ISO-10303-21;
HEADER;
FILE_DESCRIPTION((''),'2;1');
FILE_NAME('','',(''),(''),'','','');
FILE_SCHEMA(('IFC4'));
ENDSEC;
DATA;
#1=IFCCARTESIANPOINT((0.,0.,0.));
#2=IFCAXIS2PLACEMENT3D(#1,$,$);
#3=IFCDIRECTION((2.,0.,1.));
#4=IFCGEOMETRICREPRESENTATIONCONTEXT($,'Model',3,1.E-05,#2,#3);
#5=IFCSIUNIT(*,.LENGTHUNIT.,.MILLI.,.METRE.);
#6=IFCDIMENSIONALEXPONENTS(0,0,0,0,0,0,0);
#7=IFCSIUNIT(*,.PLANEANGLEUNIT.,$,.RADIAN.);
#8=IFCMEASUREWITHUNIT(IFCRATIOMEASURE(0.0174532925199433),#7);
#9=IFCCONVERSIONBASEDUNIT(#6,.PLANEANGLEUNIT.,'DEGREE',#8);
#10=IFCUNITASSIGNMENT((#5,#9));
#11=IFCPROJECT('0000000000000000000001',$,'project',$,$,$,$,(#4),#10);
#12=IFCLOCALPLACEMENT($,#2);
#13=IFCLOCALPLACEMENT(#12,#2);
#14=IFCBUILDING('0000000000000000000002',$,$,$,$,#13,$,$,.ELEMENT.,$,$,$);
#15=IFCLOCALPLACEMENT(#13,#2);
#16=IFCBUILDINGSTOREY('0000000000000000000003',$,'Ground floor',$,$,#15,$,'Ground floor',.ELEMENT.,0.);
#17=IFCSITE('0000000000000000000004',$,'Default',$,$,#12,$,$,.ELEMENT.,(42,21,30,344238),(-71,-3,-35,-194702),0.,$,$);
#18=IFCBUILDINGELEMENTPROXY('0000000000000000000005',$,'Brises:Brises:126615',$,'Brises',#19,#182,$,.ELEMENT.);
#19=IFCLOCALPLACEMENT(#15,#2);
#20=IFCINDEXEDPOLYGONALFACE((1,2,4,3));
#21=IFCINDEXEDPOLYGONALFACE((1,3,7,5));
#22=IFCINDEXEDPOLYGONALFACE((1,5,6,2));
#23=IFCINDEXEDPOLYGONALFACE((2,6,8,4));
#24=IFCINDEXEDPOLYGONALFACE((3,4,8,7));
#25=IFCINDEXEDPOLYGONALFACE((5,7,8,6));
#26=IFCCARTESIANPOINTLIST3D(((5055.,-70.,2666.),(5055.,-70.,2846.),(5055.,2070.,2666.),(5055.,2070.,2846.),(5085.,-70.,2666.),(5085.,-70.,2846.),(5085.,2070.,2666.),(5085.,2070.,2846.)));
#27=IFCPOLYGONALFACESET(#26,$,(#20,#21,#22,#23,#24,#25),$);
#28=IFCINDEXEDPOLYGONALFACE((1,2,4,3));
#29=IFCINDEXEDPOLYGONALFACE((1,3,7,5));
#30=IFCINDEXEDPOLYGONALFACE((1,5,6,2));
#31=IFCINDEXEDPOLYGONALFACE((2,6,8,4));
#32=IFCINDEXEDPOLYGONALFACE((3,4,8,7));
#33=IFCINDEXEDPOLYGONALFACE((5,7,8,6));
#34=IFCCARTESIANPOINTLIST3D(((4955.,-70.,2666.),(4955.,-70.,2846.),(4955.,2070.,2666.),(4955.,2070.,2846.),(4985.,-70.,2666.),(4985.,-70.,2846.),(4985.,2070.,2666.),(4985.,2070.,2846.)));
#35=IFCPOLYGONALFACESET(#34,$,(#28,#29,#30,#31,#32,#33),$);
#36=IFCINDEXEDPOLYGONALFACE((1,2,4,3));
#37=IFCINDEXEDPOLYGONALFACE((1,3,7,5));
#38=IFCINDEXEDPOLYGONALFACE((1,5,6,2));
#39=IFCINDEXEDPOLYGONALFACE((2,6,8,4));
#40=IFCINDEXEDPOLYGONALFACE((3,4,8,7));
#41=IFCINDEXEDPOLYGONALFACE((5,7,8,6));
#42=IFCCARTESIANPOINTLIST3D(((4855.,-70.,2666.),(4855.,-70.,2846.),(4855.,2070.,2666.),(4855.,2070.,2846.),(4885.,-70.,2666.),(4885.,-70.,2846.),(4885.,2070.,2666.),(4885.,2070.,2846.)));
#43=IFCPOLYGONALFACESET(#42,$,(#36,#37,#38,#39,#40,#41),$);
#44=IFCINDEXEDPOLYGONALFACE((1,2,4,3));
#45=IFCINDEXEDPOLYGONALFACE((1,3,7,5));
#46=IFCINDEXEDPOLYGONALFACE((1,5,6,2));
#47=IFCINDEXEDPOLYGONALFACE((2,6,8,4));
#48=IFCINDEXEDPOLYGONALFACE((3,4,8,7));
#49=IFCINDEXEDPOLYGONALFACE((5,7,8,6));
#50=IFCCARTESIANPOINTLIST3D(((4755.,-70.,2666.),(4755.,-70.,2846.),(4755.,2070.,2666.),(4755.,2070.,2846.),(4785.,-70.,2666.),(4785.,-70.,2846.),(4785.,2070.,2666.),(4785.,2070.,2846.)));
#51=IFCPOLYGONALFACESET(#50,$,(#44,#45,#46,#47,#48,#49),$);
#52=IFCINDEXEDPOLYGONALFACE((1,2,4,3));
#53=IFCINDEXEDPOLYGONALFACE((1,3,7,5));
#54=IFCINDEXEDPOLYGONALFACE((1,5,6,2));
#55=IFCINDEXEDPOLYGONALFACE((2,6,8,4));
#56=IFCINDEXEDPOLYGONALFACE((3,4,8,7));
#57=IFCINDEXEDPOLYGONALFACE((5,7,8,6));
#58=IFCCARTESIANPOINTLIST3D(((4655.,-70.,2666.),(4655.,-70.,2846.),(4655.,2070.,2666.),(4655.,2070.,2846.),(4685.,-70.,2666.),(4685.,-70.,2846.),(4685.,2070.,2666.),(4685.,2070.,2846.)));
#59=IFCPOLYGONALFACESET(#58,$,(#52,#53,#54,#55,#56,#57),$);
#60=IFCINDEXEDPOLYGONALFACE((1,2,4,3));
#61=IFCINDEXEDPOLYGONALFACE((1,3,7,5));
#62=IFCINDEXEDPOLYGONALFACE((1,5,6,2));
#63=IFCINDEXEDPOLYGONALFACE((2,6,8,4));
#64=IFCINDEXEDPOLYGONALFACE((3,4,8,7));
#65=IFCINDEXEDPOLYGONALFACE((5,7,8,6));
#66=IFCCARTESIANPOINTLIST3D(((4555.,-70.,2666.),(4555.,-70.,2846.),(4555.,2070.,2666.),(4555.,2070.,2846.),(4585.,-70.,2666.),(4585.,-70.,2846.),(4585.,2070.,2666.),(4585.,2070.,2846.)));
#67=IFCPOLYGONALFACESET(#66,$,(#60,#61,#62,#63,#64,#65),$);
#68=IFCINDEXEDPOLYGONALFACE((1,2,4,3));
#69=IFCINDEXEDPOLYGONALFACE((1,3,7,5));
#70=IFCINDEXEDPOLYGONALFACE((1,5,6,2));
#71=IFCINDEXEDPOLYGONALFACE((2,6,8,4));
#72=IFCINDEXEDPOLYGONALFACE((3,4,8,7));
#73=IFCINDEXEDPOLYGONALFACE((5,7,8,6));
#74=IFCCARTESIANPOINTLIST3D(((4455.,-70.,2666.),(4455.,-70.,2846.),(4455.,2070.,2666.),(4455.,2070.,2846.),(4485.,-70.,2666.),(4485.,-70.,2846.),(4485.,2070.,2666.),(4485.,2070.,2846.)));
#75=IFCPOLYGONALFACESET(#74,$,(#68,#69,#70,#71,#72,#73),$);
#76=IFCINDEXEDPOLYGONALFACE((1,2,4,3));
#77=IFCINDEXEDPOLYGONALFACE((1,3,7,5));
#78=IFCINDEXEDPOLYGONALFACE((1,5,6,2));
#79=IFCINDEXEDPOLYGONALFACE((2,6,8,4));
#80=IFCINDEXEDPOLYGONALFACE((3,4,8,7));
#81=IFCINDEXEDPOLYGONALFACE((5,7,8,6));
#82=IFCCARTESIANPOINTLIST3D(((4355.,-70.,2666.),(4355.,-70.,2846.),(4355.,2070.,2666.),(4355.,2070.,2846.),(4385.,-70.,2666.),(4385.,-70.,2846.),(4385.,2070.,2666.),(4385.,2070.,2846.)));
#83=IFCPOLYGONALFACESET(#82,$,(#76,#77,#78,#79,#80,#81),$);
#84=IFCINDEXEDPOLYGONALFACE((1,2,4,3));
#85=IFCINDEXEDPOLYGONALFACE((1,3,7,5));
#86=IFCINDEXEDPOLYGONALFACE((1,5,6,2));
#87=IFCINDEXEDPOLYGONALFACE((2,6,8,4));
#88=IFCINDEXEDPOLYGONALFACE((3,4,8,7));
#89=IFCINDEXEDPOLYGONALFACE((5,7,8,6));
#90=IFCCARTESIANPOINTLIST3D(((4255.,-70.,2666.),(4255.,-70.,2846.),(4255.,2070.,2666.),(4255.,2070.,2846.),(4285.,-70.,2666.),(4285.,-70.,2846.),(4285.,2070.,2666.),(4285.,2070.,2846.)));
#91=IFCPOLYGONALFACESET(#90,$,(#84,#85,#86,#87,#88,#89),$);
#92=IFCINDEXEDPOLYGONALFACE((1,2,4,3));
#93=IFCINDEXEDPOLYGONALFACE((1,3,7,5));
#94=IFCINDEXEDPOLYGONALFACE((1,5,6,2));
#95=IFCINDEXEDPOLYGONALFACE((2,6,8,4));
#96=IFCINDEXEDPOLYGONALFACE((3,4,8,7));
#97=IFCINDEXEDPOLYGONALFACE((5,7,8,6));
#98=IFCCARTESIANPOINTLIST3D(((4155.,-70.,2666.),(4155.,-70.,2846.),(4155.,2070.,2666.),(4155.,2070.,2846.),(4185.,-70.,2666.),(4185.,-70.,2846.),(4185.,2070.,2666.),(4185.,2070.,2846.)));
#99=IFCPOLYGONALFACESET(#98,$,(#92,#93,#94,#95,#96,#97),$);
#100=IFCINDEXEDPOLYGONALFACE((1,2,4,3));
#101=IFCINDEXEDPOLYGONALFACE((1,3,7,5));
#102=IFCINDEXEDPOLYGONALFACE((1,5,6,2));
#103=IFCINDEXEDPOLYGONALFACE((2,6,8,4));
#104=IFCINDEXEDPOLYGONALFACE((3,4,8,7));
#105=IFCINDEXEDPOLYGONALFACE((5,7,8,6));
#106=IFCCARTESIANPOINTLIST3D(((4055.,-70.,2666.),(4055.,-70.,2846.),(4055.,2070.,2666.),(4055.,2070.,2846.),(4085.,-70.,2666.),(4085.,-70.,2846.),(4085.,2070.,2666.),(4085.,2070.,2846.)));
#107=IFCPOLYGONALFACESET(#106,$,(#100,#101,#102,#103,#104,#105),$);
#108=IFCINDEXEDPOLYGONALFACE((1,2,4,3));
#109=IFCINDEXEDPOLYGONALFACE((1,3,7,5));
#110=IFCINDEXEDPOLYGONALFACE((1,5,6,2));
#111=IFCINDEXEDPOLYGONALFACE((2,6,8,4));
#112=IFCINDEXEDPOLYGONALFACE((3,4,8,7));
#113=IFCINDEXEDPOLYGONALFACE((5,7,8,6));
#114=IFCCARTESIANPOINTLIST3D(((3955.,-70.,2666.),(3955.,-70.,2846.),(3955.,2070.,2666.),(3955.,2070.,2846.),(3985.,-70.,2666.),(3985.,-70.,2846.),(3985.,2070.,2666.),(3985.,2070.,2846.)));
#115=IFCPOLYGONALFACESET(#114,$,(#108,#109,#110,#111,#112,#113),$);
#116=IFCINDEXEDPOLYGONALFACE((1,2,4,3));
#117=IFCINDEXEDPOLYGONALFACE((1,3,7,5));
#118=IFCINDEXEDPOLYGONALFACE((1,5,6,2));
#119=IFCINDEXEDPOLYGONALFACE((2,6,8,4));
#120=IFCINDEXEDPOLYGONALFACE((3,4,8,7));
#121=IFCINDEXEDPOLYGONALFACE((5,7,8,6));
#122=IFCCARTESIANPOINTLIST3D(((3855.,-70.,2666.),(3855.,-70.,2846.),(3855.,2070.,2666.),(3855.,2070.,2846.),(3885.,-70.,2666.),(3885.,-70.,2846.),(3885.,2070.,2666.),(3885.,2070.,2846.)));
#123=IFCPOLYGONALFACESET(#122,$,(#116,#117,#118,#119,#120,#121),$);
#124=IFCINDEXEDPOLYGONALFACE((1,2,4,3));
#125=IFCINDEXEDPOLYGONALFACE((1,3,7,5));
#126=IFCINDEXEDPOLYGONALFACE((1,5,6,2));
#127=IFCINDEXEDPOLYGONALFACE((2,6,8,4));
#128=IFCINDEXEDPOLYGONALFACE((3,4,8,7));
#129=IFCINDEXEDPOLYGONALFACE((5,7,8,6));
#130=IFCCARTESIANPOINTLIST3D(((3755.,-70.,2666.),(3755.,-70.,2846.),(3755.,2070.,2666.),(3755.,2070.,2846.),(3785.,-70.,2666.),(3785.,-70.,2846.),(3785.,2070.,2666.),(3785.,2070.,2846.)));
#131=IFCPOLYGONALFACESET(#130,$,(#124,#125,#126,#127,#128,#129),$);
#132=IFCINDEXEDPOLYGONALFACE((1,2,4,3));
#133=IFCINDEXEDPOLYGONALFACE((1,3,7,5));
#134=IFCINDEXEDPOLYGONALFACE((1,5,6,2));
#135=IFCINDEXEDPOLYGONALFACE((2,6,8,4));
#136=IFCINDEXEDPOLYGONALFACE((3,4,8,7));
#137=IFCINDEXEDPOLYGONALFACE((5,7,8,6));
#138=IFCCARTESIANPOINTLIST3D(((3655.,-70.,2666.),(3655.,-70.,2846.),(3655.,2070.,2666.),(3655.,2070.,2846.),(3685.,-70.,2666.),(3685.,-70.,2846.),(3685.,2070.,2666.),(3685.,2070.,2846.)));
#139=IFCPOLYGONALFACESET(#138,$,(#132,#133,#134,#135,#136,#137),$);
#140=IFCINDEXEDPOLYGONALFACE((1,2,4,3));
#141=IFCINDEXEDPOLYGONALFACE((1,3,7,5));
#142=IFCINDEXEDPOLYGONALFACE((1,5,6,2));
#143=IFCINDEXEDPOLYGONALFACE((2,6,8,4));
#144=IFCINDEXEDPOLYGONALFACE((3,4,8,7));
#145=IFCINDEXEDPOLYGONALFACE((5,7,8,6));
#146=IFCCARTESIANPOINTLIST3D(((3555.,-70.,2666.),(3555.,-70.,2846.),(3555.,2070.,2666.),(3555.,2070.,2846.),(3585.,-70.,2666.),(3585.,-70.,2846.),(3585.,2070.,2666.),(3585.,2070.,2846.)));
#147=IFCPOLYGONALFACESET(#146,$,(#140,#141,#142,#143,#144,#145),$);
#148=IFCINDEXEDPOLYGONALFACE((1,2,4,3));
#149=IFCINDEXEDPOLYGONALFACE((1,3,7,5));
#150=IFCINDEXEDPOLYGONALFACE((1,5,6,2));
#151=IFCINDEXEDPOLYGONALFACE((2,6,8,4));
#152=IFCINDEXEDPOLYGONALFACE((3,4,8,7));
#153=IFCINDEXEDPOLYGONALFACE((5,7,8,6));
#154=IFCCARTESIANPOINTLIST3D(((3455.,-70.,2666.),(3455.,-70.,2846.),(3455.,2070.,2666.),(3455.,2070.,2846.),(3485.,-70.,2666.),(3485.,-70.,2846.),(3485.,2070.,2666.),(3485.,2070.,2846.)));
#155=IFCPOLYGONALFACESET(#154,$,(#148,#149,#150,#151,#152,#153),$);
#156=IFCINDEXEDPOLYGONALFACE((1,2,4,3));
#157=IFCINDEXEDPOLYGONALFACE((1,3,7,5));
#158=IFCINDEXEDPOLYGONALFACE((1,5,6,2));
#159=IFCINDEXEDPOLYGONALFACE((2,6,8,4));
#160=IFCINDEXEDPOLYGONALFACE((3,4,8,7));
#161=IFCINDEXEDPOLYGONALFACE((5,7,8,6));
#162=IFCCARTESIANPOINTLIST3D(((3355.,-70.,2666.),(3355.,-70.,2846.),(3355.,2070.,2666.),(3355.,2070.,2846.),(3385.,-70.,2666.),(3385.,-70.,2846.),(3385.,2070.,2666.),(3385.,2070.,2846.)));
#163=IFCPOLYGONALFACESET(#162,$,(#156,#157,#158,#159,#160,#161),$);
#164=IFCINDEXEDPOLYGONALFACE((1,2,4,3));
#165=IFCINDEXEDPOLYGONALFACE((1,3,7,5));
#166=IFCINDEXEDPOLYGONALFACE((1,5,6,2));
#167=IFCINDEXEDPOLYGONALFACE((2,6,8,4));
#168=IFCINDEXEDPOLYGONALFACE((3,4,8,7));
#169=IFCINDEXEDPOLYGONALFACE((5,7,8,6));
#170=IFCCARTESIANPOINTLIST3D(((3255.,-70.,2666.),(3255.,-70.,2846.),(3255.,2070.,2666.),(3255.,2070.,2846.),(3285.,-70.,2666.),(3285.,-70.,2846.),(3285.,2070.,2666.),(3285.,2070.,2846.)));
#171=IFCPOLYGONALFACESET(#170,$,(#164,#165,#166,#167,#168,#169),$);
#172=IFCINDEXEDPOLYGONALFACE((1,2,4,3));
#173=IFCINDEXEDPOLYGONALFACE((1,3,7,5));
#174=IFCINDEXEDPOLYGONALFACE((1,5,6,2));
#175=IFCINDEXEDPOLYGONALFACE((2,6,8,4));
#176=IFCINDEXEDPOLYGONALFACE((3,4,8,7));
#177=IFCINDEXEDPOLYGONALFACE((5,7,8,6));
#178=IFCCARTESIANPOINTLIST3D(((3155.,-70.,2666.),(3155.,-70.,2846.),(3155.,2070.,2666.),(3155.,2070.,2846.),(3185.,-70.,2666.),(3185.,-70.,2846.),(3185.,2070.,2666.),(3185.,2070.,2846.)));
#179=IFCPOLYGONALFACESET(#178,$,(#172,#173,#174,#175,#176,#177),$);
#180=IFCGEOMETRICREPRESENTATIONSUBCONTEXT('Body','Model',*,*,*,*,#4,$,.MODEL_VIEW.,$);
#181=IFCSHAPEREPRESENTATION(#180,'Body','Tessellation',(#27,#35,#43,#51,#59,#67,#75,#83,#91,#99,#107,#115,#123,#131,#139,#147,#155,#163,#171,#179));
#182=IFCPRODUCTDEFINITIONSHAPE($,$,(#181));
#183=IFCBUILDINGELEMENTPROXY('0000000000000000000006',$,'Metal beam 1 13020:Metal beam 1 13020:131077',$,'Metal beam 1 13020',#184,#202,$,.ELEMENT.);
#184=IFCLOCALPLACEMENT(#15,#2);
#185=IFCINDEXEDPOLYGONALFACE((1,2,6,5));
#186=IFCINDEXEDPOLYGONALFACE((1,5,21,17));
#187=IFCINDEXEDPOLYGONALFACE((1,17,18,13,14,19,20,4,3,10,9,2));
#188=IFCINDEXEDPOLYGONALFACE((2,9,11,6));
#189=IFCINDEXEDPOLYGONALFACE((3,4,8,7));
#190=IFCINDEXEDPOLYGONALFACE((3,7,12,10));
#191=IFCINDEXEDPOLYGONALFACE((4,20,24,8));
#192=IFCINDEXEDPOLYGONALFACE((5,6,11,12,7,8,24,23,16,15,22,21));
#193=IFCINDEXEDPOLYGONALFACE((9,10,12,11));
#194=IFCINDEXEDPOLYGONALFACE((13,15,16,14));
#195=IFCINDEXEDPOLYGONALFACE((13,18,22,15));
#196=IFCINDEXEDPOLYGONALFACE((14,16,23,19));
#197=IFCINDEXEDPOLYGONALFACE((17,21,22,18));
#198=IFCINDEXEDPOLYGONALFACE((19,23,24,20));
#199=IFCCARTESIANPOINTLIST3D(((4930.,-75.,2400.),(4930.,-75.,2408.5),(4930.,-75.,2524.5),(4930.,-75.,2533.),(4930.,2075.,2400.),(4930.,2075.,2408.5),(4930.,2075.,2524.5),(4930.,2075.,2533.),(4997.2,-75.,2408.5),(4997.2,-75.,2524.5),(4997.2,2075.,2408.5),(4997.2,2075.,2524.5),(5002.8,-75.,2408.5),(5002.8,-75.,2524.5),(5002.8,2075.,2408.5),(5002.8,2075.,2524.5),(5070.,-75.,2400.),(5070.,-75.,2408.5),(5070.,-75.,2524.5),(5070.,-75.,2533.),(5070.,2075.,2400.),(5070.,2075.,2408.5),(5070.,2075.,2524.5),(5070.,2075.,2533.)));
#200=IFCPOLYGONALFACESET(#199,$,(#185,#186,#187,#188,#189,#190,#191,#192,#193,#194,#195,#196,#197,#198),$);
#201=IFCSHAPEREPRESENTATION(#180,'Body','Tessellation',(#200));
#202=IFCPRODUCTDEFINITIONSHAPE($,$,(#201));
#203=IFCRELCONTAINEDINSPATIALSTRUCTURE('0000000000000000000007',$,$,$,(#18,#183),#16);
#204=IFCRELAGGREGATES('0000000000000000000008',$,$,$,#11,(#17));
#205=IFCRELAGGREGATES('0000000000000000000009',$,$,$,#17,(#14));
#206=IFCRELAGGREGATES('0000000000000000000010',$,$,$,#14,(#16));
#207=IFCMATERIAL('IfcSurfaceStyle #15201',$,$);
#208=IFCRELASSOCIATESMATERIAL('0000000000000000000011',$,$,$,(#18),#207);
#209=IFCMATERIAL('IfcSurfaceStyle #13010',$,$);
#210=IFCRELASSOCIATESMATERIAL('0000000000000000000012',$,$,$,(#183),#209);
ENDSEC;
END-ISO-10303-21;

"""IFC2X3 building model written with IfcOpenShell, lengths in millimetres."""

from ifc_helpers import new_model, entity, si_unit, converted_unit, direction, frame, frame_2d, origin, origin_2d_with_axis, place, context, subcontext, project, spatial, rectangle, i_section, extrude, source, transform, mapped, material, element, save


model = new_model("IFC2X3")

# Units and contexts
model_context = context("Model", 3, precision=1e-05, world=origin(), true_north=direction((2.0, 0.0, 1.0)))
body_context = subcontext(model_context, "Body", "Model", "MODEL_VIEW")
ifc_project = project(units=[si_unit("LENGTHUNIT", "METRE", prefix="MILLI"), converted_unit("PLANEANGLEUNIT", "DEGREE", entity("IfcRatioMeasure", 0.0174532925199433), si_unit("PLANEANGLEUNIT", "RADIAN"), dimensions=[0, 0, 0, 0, 0, 0, 0])], contexts=[model_context])

# Site, building, storey
site_placement = place(None, origin())
site = spatial("IfcSite", under=ifc_project, at=site_placement, Name="Default", CompositionType="ELEMENT", RefLatitude=(42, 21, 30, 344238), RefLongitude=(-71, -3, -35, -194702), RefElevation=0.0)
building_placement = place(site_placement, origin())
building = spatial("IfcBuilding", under=site, at=building_placement, CompositionType="ELEMENT")
storey_placement = place(building_placement, origin())
storey = spatial("IfcBuildingStorey", under=building, at=storey_placement, Name="Ground floor", LongName="Ground floor", CompositionType="ELEMENT", Elevation=0.0)

# Building element proxies
ifc_material_1 = material(Name="IfcSurfaceStyle #15201")
shared_shape_1 = source(origin(), body_context, "Body", "SweptSolid", [
    extrude(rectangle(XDim=2140.0, YDim=30.0, at=frame_2d((0.0, 0.0), x_axis=(1.0, 0.0))), frame((5070.0, 1000.0, 2666.0), z_axis=(0.0, 0.0, 1.0), x_axis=(0.0, -1.0, 0.0)), (0.0, 0.0, 1.0), 180.0),
    extrude(rectangle(XDim=2140.0, YDim=30.0, at=frame_2d((0.0, 0.0), x_axis=(1.0, 0.0))), frame((4970.0, 1000.0, 2666.0), z_axis=(0.0, 0.0, 1.0), x_axis=(0.0, -1.0, 0.0)), (0.0, 0.0, 1.0), 180.0),
    extrude(rectangle(XDim=2140.0, YDim=30.0, at=frame_2d((0.0, 0.0), x_axis=(1.0, 0.0))), frame((4870.0, 1000.0, 2666.0), z_axis=(0.0, 0.0, 1.0), x_axis=(0.0, -1.0, 0.0)), (0.0, 0.0, 1.0), 180.0),
    extrude(rectangle(XDim=2140.0, YDim=30.0, at=origin_2d_with_axis()), frame((4770.0, 1000.0, 2666.0), z_axis=(0.0, 0.0, 1.0), x_axis=(0.0, -1.0, 0.0)), (0.0, 0.0, 1.0), 180.0),
    extrude(rectangle(XDim=2140.0, YDim=30.0, at=origin_2d_with_axis()), frame((4670.0, 1000.0, 2666.0), z_axis=(0.0, 0.0, 1.0), x_axis=(0.0, -1.0, 0.0)), (0.0, 0.0, 1.0), 180.0),
    extrude(rectangle(XDim=2140.0, YDim=30.0, at=origin_2d_with_axis()), frame((4570.0, 1000.0, 2666.0), z_axis=(0.0, 0.0, 1.0), x_axis=(0.0, -1.0, 0.0)), (0.0, 0.0, 1.0), 180.0),
    extrude(rectangle(XDim=2140.0, YDim=30.0, at=origin_2d_with_axis()), frame((4470.0, 1000.0, 2666.0), z_axis=(0.0, 0.0, 1.0), x_axis=(0.0, -1.0, 0.0)), (0.0, 0.0, 1.0), 180.0),
    extrude(rectangle(XDim=2140.0, YDim=30.0, at=origin_2d_with_axis()), frame((4370.0, 1000.0, 2666.0), z_axis=(0.0, 0.0, 1.0), x_axis=(0.0, -1.0, 0.0)), (0.0, 0.0, 1.0), 180.0),
    extrude(rectangle(XDim=2140.0, YDim=30.0, at=origin_2d_with_axis()), frame((4270.0, 1000.0, 2666.0), z_axis=(0.0, 0.0, 1.0), x_axis=(0.0, -1.0, 0.0)), (0.0, 0.0, 1.0), 180.0),
    extrude(rectangle(XDim=2140.0, YDim=30.0, at=origin_2d_with_axis()), frame((4170.0, 1000.0, 2666.0), z_axis=(0.0, 0.0, 1.0), x_axis=(0.0, -1.0, 0.0)), (0.0, 0.0, 1.0), 180.0),
    extrude(rectangle(XDim=2140.0, YDim=30.0, at=origin_2d_with_axis()), frame((4070.0, 1000.0, 2666.0), z_axis=(0.0, 0.0, 1.0), x_axis=(0.0, -1.0, 0.0)), (0.0, 0.0, 1.0), 180.0),
    extrude(rectangle(XDim=2140.0, YDim=30.0, at=origin_2d_with_axis()), frame((3970.0, 1000.0, 2666.0), z_axis=(0.0, 0.0, 1.0), x_axis=(0.0, -1.0, 0.0)), (0.0, 0.0, 1.0), 180.0),
    extrude(rectangle(XDim=2140.0, YDim=30.0, at=origin_2d_with_axis()), frame((3870.0, 1000.0, 2666.0), z_axis=(0.0, 0.0, 1.0), x_axis=(0.0, -1.0, 0.0)), (0.0, 0.0, 1.0), 180.0),
    extrude(rectangle(XDim=2140.0, YDim=30.0, at=origin_2d_with_axis()), frame((3770.0, 1000.0, 2666.0), z_axis=(0.0, 0.0, 1.0), x_axis=(0.0, -1.0, 0.0)), (0.0, 0.0, 1.0), 180.0),
    extrude(rectangle(XDim=2140.0, YDim=30.0, at=origin_2d_with_axis()), frame((3670.0, 1000.0, 2666.0), z_axis=(0.0, 0.0, 1.0), x_axis=(0.0, -1.0, 0.0)), (0.0, 0.0, 1.0), 180.0),
    extrude(rectangle(XDim=2140.0, YDim=30.0, at=origin_2d_with_axis()), frame((3570.0, 1000.0, 2666.0), z_axis=(0.0, 0.0, 1.0), x_axis=(0.0, -1.0, 0.0)), (0.0, 0.0, 1.0), 180.0),
    extrude(rectangle(XDim=2140.0, YDim=30.0, at=origin_2d_with_axis()), frame((3470.0, 1000.0, 2666.0), z_axis=(0.0, 0.0, 1.0), x_axis=(0.0, -1.0, 0.0)), (0.0, 0.0, 1.0), 180.0),
    extrude(rectangle(XDim=2140.0, YDim=30.0, at=origin_2d_with_axis()), frame((3370.0, 1000.0, 2666.0), z_axis=(0.0, 0.0, 1.0), x_axis=(0.0, -1.0, 0.0)), (0.0, 0.0, 1.0), 180.0),
    extrude(rectangle(XDim=2140.0, YDim=30.0, at=origin_2d_with_axis()), frame((3270.0, 1000.0, 2666.0), z_axis=(0.0, 0.0, 1.0), x_axis=(0.0, -1.0, 0.0)), (0.0, 0.0, 1.0), 180.0),
    extrude(rectangle(XDim=2140.0, YDim=30.0, at=origin_2d_with_axis()), frame((3170.0, 1000.0, 2666.0), z_axis=(0.0, 0.0, 1.0), x_axis=(0.0, -1.0, 0.0)), (0.0, 0.0, 1.0), 180.0),
])
proxy_1_placement = place(storey_placement, origin())
element("IfcBuildingElementProxy", 1, at=proxy_1_placement, inside=storey, material=ifc_material_1, Name="Brises:Brises:126615", ObjectType="Brises", CompositionType="ELEMENT", context=body_context, shape_type="MappedRepresentation", body=[
    mapped(shared_shape_1, transform((0.0, 0.0, 0.0), scale=1.0)),
])
ifc_material_2 = material(Name="IfcSurfaceStyle #13010")
shared_shape_2 = source(origin(), body_context, "Body", "SweptSolid", [
    extrude(i_section(OverallWidth=140.0, OverallDepth=133.0, WebThickness=5.5, FlangeThickness=8.5, at=frame_2d((0.0, 0.0), x_axis=(1.0, 0.0))), frame((5000.0, -75.0, 2466.5), z_axis=(0.0, 1.0, 0.0), x_axis=(-1.0, 0.0, 0.0)), (0.0, 0.0, 1.0), 2150.0),
])
proxy_2_placement = place(storey_placement, origin())
element("IfcBuildingElementProxy", 2, at=proxy_2_placement, inside=storey, material=ifc_material_2, Name="Metal beam 1 13020:Metal beam 1 13020:131077", ObjectType="Metal beam 1 13020", CompositionType="ELEMENT", context=body_context, shape_type="MappedRepresentation", body=[
    mapped(shared_shape_2, transform((0.0, 0.0, 0.0), scale=1.0)),
])

save(model, "model.ifc")
